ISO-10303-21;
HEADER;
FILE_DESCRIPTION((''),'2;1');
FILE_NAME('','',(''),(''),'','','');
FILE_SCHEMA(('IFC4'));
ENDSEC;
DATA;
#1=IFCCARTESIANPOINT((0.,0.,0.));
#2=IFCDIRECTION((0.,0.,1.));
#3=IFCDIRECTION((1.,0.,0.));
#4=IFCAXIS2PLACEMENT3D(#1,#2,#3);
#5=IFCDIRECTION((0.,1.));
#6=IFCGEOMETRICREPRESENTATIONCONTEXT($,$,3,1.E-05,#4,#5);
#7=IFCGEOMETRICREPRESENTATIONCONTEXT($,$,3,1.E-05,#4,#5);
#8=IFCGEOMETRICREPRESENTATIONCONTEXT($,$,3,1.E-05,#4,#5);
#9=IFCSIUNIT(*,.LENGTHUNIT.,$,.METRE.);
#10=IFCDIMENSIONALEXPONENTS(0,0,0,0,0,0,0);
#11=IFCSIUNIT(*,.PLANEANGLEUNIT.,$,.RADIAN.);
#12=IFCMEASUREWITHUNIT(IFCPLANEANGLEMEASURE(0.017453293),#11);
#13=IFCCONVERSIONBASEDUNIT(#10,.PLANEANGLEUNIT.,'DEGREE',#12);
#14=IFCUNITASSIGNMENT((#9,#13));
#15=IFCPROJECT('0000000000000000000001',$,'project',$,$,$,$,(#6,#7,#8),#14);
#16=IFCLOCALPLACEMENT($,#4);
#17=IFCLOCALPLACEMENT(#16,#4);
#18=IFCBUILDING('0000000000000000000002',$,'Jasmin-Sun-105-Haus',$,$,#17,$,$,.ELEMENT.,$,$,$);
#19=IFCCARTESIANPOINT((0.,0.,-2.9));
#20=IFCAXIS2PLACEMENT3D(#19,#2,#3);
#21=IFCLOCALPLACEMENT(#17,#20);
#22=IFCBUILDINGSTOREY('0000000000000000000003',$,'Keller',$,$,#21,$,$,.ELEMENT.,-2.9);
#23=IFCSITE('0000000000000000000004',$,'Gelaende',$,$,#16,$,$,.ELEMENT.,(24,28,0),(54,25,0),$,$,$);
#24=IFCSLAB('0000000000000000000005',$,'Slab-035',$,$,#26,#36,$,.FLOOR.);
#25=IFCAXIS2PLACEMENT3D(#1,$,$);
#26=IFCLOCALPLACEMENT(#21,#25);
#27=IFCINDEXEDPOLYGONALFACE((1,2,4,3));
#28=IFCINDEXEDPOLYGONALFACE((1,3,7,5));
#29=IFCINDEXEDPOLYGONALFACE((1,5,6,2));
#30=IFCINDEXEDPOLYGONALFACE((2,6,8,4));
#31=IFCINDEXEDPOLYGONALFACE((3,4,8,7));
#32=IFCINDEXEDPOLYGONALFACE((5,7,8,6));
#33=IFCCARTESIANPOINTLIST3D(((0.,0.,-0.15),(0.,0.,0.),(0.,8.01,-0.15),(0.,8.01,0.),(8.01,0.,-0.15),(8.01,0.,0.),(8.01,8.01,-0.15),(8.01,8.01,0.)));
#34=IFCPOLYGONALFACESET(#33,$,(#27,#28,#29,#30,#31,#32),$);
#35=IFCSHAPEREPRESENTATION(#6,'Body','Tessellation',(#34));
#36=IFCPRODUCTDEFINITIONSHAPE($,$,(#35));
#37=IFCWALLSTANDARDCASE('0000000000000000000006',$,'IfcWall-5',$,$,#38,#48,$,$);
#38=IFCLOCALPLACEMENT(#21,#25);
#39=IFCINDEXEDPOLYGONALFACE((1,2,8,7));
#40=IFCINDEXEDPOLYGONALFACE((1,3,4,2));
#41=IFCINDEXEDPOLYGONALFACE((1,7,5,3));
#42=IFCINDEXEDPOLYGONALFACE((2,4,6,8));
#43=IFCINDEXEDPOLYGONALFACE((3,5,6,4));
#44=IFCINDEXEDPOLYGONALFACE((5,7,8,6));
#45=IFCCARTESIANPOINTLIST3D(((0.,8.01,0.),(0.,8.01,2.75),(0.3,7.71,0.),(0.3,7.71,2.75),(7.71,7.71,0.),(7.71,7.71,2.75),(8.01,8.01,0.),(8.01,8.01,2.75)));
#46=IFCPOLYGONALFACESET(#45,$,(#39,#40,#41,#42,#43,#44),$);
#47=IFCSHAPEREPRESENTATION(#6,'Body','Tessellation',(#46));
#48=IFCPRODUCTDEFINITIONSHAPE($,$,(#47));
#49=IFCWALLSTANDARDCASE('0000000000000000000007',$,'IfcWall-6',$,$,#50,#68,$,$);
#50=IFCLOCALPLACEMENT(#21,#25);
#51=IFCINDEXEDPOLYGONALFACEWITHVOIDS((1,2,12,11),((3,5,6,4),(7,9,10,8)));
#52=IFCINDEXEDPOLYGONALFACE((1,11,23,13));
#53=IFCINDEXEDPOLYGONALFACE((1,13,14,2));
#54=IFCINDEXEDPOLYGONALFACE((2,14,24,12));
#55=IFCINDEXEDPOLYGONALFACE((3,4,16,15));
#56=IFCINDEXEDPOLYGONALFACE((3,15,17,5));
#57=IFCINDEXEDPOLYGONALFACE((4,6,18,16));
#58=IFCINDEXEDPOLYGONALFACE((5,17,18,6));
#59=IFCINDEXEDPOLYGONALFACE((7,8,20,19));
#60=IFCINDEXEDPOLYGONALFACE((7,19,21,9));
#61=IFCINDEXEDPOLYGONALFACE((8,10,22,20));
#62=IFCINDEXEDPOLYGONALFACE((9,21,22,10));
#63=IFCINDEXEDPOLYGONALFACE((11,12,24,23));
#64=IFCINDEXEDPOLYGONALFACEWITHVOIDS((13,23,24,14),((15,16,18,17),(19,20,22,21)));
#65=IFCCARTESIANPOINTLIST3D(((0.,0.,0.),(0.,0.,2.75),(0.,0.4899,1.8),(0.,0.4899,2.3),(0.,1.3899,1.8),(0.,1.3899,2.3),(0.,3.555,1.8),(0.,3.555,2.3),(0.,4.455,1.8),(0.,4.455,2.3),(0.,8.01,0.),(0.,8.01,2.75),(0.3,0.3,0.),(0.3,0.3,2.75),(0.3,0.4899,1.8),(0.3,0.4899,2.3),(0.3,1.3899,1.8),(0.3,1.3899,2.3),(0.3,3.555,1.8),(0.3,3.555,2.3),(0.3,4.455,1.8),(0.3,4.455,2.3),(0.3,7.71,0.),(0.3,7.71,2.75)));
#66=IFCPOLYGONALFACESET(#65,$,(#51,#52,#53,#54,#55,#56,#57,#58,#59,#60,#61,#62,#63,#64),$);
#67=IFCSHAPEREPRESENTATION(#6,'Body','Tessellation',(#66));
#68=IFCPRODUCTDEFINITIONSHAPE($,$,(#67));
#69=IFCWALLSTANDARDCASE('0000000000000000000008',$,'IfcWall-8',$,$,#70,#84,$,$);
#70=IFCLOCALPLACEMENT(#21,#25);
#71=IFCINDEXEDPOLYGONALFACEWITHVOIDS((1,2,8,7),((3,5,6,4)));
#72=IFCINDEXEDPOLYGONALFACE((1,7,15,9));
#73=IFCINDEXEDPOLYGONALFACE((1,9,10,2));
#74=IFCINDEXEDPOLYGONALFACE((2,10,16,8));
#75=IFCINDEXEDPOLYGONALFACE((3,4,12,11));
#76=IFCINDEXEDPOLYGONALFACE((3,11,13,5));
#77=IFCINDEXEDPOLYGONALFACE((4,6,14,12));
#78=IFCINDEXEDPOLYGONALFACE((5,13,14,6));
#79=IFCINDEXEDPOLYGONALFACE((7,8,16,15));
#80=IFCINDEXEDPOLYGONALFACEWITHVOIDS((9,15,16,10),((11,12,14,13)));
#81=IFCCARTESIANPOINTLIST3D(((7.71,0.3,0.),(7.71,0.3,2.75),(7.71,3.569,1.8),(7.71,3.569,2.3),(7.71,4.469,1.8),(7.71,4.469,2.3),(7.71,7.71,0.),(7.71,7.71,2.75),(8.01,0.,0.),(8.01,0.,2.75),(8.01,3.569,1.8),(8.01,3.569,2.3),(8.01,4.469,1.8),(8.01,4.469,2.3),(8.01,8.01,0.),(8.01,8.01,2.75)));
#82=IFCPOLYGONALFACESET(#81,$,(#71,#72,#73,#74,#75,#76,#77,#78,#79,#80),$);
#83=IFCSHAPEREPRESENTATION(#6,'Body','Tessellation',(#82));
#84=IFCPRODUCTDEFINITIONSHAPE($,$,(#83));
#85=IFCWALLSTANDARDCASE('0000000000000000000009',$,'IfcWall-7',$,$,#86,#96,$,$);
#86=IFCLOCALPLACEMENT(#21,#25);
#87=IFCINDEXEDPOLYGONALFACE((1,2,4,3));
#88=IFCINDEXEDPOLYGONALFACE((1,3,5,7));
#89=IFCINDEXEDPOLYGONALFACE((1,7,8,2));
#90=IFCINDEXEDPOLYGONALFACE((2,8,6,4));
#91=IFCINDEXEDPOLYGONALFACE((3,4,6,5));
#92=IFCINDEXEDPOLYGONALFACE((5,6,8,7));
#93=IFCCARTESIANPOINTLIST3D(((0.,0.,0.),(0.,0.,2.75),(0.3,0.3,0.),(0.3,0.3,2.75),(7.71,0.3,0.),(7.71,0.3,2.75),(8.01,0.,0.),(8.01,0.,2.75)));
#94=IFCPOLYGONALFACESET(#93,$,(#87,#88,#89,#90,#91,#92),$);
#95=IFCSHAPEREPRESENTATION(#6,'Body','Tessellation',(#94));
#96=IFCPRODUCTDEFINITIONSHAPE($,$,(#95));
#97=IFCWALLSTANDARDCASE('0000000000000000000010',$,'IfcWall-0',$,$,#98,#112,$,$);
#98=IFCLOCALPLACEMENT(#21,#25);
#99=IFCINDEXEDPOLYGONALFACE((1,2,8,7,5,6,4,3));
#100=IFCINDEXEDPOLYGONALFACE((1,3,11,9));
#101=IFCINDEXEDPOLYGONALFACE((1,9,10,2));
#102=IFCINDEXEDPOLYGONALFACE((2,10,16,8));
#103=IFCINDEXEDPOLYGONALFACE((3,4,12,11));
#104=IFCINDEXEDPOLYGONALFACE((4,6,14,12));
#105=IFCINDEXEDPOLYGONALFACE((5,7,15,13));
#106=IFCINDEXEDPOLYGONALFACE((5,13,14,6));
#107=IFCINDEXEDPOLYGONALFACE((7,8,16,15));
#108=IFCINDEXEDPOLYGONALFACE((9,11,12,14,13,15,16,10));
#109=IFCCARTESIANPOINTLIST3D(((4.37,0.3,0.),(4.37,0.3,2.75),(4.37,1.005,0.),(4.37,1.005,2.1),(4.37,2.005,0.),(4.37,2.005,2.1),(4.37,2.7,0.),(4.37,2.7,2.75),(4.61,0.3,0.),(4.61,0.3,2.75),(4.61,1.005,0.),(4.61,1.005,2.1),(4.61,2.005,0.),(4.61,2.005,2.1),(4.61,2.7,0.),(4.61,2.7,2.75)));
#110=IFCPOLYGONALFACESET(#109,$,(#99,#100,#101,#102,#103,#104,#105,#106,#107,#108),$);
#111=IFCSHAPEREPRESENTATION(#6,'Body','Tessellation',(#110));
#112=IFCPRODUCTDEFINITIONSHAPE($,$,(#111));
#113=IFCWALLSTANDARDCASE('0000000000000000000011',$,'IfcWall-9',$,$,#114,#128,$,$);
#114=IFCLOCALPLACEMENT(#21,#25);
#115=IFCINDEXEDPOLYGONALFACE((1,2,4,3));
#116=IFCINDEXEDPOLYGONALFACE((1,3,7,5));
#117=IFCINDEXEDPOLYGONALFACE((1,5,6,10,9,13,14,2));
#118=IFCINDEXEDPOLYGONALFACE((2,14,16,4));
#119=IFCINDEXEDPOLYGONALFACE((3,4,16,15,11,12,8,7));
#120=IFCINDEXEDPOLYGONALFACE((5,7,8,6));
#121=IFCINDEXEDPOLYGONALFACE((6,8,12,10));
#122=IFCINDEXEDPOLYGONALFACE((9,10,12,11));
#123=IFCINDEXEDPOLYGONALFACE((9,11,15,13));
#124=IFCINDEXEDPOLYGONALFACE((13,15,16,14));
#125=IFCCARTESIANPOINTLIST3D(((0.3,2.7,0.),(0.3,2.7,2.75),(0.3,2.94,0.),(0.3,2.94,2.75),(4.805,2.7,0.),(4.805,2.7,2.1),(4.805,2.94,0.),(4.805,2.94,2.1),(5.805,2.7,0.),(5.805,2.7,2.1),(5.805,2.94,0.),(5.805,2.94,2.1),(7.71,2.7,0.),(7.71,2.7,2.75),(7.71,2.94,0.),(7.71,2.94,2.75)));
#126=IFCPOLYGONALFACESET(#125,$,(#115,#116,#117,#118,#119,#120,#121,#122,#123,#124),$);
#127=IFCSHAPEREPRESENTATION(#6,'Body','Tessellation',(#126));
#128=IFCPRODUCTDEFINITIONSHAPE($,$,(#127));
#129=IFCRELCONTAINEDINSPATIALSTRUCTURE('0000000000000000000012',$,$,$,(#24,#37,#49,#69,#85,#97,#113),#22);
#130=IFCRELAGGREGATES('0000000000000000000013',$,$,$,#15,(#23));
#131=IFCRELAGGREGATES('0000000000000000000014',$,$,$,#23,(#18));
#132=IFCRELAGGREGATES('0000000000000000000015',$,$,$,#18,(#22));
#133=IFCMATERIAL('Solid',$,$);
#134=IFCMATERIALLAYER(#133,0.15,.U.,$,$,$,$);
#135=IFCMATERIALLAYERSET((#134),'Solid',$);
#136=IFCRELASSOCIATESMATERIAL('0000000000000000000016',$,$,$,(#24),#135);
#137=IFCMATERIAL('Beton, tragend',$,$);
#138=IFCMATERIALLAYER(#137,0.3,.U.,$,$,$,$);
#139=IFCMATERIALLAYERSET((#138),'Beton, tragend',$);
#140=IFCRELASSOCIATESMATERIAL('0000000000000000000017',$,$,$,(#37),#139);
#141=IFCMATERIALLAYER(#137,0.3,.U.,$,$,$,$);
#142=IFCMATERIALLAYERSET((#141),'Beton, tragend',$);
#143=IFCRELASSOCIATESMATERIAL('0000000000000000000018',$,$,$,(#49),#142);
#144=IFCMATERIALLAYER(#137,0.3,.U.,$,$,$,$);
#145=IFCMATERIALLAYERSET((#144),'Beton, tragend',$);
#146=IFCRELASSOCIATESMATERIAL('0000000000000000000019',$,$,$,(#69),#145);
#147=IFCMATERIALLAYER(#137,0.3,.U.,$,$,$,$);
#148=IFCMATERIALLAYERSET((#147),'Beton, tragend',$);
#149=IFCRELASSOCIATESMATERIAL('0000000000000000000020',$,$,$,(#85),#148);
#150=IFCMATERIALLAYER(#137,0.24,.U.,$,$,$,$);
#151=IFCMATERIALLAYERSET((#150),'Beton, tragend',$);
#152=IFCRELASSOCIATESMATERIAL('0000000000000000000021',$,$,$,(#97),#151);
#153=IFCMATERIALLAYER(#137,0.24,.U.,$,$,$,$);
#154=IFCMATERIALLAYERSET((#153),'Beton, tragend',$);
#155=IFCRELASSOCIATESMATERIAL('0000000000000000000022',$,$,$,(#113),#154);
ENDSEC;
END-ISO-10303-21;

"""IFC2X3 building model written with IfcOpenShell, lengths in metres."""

from ifc_helpers import new_model, entity, si_unit, converted_unit, direction, frame, frame_2d, origin_with_axes, place, context, project, spatial, polyline, rectangle, outline, extrude, material, layer, layer_set, layer_usage, element, save


model = new_model("IFC2X3")

# Units and contexts
context_of_model_1 = context(None, 3, precision=1e-05, world=origin_with_axes(), true_north=direction((0.0, 1.0)))
context_of_model_2 = context(None, 3, precision=1e-05, world=origin_with_axes(), true_north=direction((0.0, 1.0)))
context_of_model_3 = context(None, 3, precision=1e-05, world=origin_with_axes(), true_north=direction((0.0, 1.0)))
ifc_project = project(units=[si_unit("LENGTHUNIT", "METRE"), converted_unit("PLANEANGLEUNIT", "DEGREE", entity("IfcPlaneAngleMeasure", 0.017453293), si_unit("PLANEANGLEUNIT", "RADIAN"), dimensions=[0, 0, 0, 0, 0, 0, 0])], contexts=[context_of_model_1, context_of_model_2, context_of_model_3])

# Site, building, storey
site_placement = place(None, origin_with_axes())
site = spatial("IfcSite", under=ifc_project, at=site_placement, Name="Gelaende", CompositionType="ELEMENT", RefLatitude=(24, 28, 0), RefLongitude=(54, 25, 0))
building_placement = place(site_placement, origin_with_axes())
building = spatial("IfcBuilding", under=site, at=building_placement, Name="Jasmin-Sun-105-Haus", CompositionType="ELEMENT")
storey_placement = place(building_placement, frame((0.0, 0.0, -2.9), z_axis=(0.0, 0.0, 1.0), x_axis=(1.0, 0.0, 0.0)))
storey = spatial("IfcBuildingStorey", under=building, at=storey_placement, Name="Keller", CompositionType="ELEMENT", Elevation=-2.9)

# Slab
ifc_material_1 = material(Name="Solid")
ifc_layer_1 = layer(ifc_material_1, 0.15, ventilated="UNKNOWN")
ifc_layer_set_1 = layer_set([ifc_layer_1], Name="Solid")
ifc_layer_usage_1 = layer_usage(ifc_layer_set_1, "AXIS3", "NEGATIVE", 0.15)
slab_placement = place(storey_placement, frame((0.0, 8.01, -0.15), z_axis=(0.0, 0.0, 1.0), x_axis=(1.0, 0.0, 0.0)))
element("IfcSlab", 1, at=slab_placement, inside=storey, material=ifc_layer_usage_1, Name="Slab-035", PredefinedType="FLOOR", context=context_of_model_1, shape_type="SweptSolid", body=[
    extrude(outline(polyline([(0.0, 0.0), (8.01, 0.0), (8.01, -8.01), (0.0, -8.01), (0.0, 0.0)])), origin_with_axes(), (0.0, 0.0, 1.0), 0.15),
])

# Wall
ifc_material_2 = material(Name="Beton, tragend")
ifc_layer_2 = layer(ifc_material_2, 0.3, ventilated="UNKNOWN")
ifc_layer_set_2 = layer_set([ifc_layer_2], Name="Beton, tragend")
ifc_layer_usage_2 = layer_usage(ifc_layer_set_2, "AXIS2", "POSITIVE", 0.0)
wall_1_placement = place(storey_placement, frame((8.01, 8.01, 0.0), z_axis=(0.0, 0.0, 1.0), x_axis=(-1.0, 0.0, 0.0)))
element("IfcWallStandardCase", 2, at=wall_1_placement, inside=storey, material=ifc_layer_usage_2, Name="IfcWall-5", context=context_of_model_1, shape_type="SweptSolid", body=[
    extrude(outline(polyline([(0.0, 0.0), (8.01, 0.0), (7.71, 0.3), (0.3, 0.3), (0.0, 0.0)])), origin_with_axes(), (0.0, 0.0, 1.0), 2.75),
])

# Wall, openings
ifc_layer_3 = layer(ifc_material_2, 0.3, ventilated="UNKNOWN")
ifc_layer_set_3 = layer_set([ifc_layer_3], Name="Beton, tragend")
ifc_layer_usage_3 = layer_usage(ifc_layer_set_3, "AXIS2", "POSITIVE", 0.0)
wall_2_placement = place(storey_placement, frame((0.0, 8.01, 0.0), z_axis=(0.0, 0.0, 1.0), x_axis=(0.0, -1.0, 0.0)))
wall_2 = element("IfcWallStandardCase", 3, at=wall_2_placement, inside=storey, material=ifc_layer_usage_3, Name="IfcWall-6", context=context_of_model_1, shape_type="SweptSolid", body=[
    extrude(outline(polyline([(0.0, 0.0), (8.01, 0.0), (7.71, 0.3), (0.3, 0.3), (0.0, 0.0)])), origin_with_axes(), (0.0, 0.0, 1.0), 2.75),
])
opening_1_placement = place(wall_2_placement, frame((4.005, 0.0, 1.8), z_axis=(0.0, 0.0, 1.0), x_axis=(1.0, 0.0, 0.0)))
element("IfcOpeningElement", 4, at=opening_1_placement, cuts=wall_2, context=context_of_model_1, shape_type="SweptSolid", body=[
    extrude(rectangle(XDim=0.5, YDim=0.9, at=frame_2d((0.0, 0.25), x_axis=(0.0, -1.0))), frame((0.0, 0.0, 0.0), z_axis=(0.0, 1.0, 0.0), x_axis=(-1.0, 0.0, 0.0)), (0.0, 0.0, 1.0), 0.3),
])
opening_2_placement = place(wall_2_placement, frame((7.0701, 0.0, 1.8), z_axis=(0.0, 0.0, 1.0), x_axis=(1.0, 0.0, 0.0)))
element("IfcOpeningElement", 5, at=opening_2_placement, cuts=wall_2, context=context_of_model_1, shape_type="SweptSolid", body=[
    extrude(rectangle(XDim=0.5, YDim=0.9, at=frame_2d((0.0, 0.25), x_axis=(0.0, -1.0))), frame((0.0, 0.0, 0.0), z_axis=(0.0, 1.0, 0.0), x_axis=(-1.0, 0.0, 0.0)), (0.0, 0.0, 1.0), 0.3),
])

# Wall, opening
ifc_layer_4 = layer(ifc_material_2, 0.3, ventilated="UNKNOWN")
ifc_layer_set_4 = layer_set([ifc_layer_4], Name="Beton, tragend")
ifc_layer_usage_4 = layer_usage(ifc_layer_set_4, "AXIS2", "POSITIVE", 0.0)
wall_3_placement = place(storey_placement, frame((8.01, 0.0, 0.0), z_axis=(0.0, 0.0, 1.0), x_axis=(0.0, 1.0, 0.0)))
wall_3 = element("IfcWallStandardCase", 6, at=wall_3_placement, inside=storey, material=ifc_layer_usage_4, Name="IfcWall-8", context=context_of_model_1, shape_type="SweptSolid", body=[
    extrude(outline(polyline([(0.0, 0.0), (8.01, 0.0), (7.71, 0.3), (0.3, 0.3), (0.0, 0.0)])), origin_with_axes(), (0.0, 0.0, 1.0), 2.75),
])
opening_3_placement = place(wall_3_placement, frame((4.019, 0.0, 1.8), z_axis=(0.0, 0.0, 1.0), x_axis=(1.0, 0.0, 0.0)))
element("IfcOpeningElement", 7, at=opening_3_placement, cuts=wall_3, context=context_of_model_1, shape_type="SweptSolid", body=[
    extrude(rectangle(XDim=0.5, YDim=0.9, at=frame_2d((0.0, 0.25), x_axis=(0.0, -1.0))), frame((0.0, 0.0, 0.0), z_axis=(0.0, 1.0, 0.0), x_axis=(-1.0, 0.0, 0.0)), (0.0, 0.0, 1.0), 0.3),
])

# Wall
ifc_layer_5 = layer(ifc_material_2, 0.3, ventilated="UNKNOWN")
ifc_layer_set_5 = layer_set([ifc_layer_5], Name="Beton, tragend")
ifc_layer_usage_5 = layer_usage(ifc_layer_set_5, "AXIS2", "POSITIVE", 0.0)
wall_4_placement = place(storey_placement, origin_with_axes())
element("IfcWallStandardCase", 8, at=wall_4_placement, inside=storey, material=ifc_layer_usage_5, Name="IfcWall-7", context=context_of_model_1, shape_type="SweptSolid", body=[
    extrude(outline(polyline([(0.0, 0.0), (8.01, 0.0), (7.71, 0.3), (0.3, 0.3), (0.0, 0.0)])), origin_with_axes(), (0.0, 0.0, 1.0), 2.75),
])

# Walls, openings
ifc_layer_6 = layer(ifc_material_2, 0.24, ventilated="UNKNOWN")
ifc_layer_set_6 = layer_set([ifc_layer_6], Name="Beton, tragend")
ifc_layer_usage_6 = layer_usage(ifc_layer_set_6, "AXIS2", "POSITIVE", 0.0)
wall_5_placement = place(storey_placement, frame((4.61, 0.0, 0.0), z_axis=(0.0, 0.0, 1.0), x_axis=(0.0, 1.0, 0.0)))
wall_5 = element("IfcWallStandardCase", 9, at=wall_5_placement, inside=storey, material=ifc_layer_usage_6, Name="IfcWall-0", context=context_of_model_1, shape_type="SweptSolid", body=[
    extrude(outline(polyline([(0.3, 0.0), (2.7, 0.0), (2.7, 0.24), (0.3, 0.24), (0.3, 0.0)])), origin_with_axes(), (0.0, 0.0, 1.0), 2.75),
])
opening_4_placement = place(wall_5_placement, frame((1.505, 0.0, 0.0), z_axis=(0.0, 0.0, 1.0), x_axis=(1.0, 0.0, 0.0)))
element("IfcOpeningElement", 10, at=opening_4_placement, cuts=wall_5, context=context_of_model_1, shape_type="SweptSolid", body=[
    extrude(rectangle(XDim=2.1, YDim=1.0, at=frame_2d((0.0, 1.05), x_axis=(0.0, -1.0))), frame((0.0, 0.0, 0.0), z_axis=(0.0, 1.0, 0.0), x_axis=(-1.0, 0.0, 0.0)), (0.0, 0.0, 1.0), 0.24),
])
ifc_layer_7 = layer(ifc_material_2, 0.24, ventilated="UNKNOWN")
ifc_layer_set_7 = layer_set([ifc_layer_7], Name="Beton, tragend")
ifc_layer_usage_7 = layer_usage(ifc_layer_set_7, "AXIS2", "POSITIVE", 0.0)
wall_6_placement = place(storey_placement, frame((0.0, 2.7, 0.0), z_axis=(0.0, 0.0, 1.0), x_axis=(1.0, 0.0, 0.0)))
wall_6 = element("IfcWallStandardCase", 11, at=wall_6_placement, inside=storey, material=ifc_layer_usage_7, Name="IfcWall-9", context=context_of_model_1, shape_type="SweptSolid", body=[
    extrude(outline(polyline([(0.3, 0.0), (7.71, 0.0), (7.71, 0.24), (0.3, 0.24), (0.3, 0.0)])), origin_with_axes(), (0.0, 0.0, 1.0), 2.75),
])
opening_5_placement = place(wall_6_placement, frame((5.305, 0.0, 0.0), z_axis=(0.0, 0.0, 1.0), x_axis=(1.0, 0.0, 0.0)))
element("IfcOpeningElement", 12, at=opening_5_placement, cuts=wall_6, context=context_of_model_1, shape_type="SweptSolid", body=[
    extrude(rectangle(XDim=2.1, YDim=1.0, at=frame_2d((0.0, 1.05), x_axis=(0.0, -1.0))), frame((0.0, 0.0, 0.0), z_axis=(0.0, 1.0, 0.0), x_axis=(-1.0, 0.0, 0.0)), (0.0, 0.0, 1.0), 0.24),
])

save(model, "model.ifc")
